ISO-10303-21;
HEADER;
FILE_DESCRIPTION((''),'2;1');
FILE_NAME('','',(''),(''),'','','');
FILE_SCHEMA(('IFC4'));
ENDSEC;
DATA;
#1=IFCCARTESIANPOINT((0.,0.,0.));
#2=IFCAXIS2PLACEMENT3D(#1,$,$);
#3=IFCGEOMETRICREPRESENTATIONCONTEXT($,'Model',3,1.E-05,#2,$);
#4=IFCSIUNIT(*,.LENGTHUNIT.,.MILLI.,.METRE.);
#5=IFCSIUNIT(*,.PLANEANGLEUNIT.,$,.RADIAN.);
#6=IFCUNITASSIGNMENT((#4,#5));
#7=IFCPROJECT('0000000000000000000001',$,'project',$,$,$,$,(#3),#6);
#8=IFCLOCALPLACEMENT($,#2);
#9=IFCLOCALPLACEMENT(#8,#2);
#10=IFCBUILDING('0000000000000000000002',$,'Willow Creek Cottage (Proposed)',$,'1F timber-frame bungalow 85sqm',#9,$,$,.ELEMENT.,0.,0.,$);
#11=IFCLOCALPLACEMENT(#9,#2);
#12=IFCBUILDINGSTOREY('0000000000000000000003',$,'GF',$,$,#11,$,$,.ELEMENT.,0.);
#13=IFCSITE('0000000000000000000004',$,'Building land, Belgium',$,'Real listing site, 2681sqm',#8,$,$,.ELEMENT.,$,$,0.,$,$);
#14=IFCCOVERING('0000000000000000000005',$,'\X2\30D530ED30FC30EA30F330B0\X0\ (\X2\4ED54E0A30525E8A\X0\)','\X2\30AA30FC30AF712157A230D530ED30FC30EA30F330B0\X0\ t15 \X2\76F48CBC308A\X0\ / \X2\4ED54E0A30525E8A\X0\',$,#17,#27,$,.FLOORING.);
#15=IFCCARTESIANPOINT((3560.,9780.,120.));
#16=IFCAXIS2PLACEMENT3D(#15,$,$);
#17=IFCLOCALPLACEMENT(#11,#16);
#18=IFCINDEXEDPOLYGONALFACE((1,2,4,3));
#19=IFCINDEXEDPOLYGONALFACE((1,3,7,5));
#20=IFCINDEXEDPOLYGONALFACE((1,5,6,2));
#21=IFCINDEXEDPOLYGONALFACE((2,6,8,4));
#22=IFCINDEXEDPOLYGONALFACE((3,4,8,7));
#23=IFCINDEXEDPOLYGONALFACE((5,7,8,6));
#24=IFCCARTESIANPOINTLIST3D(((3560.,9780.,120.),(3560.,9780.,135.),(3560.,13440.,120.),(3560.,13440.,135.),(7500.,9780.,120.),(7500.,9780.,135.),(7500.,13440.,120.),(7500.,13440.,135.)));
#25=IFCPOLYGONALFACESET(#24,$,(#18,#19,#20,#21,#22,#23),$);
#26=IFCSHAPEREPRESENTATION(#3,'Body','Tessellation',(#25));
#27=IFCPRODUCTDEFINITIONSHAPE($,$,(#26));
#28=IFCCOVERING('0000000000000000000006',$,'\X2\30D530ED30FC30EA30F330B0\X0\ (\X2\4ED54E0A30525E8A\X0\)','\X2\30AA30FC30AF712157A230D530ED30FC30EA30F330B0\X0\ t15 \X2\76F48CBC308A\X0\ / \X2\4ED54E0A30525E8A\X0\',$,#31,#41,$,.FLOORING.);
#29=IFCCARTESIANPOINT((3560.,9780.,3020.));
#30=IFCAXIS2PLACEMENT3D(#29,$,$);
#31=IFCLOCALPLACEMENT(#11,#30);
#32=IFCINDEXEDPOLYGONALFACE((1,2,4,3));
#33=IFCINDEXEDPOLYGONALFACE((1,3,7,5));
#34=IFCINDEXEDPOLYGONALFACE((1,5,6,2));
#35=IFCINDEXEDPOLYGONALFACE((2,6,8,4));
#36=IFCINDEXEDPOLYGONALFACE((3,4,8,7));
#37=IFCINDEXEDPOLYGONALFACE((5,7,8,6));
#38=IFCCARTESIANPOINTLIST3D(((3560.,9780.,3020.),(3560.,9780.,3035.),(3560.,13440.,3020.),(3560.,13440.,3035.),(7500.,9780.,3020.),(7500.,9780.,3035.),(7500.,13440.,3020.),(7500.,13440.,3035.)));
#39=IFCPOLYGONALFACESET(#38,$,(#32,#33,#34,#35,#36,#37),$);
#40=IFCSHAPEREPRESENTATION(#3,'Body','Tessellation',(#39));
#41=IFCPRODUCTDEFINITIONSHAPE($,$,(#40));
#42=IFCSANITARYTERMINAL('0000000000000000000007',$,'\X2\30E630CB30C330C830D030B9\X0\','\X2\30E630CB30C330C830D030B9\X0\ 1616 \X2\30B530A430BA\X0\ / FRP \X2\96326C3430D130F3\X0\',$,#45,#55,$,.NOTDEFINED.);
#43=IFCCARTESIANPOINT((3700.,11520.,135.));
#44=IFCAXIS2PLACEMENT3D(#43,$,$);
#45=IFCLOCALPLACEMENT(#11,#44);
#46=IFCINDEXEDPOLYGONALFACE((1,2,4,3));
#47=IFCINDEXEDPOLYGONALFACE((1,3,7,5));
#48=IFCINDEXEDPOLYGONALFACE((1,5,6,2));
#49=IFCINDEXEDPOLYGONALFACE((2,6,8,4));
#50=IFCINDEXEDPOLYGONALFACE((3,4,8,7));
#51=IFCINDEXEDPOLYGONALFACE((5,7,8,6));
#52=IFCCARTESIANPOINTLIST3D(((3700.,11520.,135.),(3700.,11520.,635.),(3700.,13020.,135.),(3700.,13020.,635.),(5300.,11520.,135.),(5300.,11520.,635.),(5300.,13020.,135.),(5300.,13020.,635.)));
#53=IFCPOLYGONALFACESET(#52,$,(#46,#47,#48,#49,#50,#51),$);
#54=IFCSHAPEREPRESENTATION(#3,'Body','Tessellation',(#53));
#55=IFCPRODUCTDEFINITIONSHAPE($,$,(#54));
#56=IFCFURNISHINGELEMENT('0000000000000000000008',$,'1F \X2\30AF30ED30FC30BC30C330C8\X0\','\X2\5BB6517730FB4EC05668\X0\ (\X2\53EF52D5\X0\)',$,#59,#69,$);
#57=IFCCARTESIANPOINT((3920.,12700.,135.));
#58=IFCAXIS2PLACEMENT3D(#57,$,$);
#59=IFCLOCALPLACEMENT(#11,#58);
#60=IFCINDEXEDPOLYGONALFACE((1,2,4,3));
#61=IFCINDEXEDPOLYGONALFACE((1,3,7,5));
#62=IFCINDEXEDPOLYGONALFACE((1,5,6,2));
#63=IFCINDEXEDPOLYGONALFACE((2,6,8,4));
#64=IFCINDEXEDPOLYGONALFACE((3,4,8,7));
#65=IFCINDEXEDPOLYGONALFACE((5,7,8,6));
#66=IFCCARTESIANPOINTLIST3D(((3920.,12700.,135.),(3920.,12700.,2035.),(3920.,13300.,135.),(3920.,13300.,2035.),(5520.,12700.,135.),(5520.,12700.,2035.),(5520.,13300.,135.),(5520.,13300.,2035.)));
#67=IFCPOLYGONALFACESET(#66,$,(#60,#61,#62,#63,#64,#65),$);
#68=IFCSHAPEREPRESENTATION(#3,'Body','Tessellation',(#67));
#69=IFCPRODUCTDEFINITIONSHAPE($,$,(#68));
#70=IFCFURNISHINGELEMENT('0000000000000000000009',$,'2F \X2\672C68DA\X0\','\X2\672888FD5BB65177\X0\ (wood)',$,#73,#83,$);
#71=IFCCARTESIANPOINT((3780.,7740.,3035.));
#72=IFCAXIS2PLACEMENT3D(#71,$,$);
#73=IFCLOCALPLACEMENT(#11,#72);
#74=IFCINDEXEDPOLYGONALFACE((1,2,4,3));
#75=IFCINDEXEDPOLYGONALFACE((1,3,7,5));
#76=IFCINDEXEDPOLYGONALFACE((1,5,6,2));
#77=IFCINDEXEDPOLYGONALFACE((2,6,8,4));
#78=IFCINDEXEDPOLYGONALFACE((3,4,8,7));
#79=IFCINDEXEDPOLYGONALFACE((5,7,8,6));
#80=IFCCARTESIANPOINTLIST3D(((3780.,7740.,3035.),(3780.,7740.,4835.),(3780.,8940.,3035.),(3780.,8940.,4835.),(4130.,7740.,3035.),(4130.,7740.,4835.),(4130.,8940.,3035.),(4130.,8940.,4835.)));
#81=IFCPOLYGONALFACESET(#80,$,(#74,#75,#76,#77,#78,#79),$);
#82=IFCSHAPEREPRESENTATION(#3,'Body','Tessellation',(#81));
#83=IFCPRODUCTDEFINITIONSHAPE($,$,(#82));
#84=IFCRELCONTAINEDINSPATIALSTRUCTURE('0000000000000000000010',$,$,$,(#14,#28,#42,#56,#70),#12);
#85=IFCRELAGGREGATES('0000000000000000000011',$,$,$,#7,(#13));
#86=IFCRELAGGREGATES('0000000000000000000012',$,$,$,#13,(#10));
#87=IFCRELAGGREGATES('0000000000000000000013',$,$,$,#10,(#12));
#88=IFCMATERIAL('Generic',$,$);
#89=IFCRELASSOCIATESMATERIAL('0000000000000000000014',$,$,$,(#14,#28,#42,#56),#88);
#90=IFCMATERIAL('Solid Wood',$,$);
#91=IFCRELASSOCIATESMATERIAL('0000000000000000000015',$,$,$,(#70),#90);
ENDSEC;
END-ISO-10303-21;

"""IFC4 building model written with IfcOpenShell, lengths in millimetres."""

from ifc_helpers import new_model, si_unit, frame, frame_2d, origin, place, context, project, spatial, rectangle, extrude, material, element, save


model = new_model("IFC4")

# Units and contexts
model_context = context("Model", 3, precision=1e-05, world=origin())
ifc_project = project(units=[si_unit("LENGTHUNIT", "METRE", prefix="MILLI"), si_unit("PLANEANGLEUNIT", "RADIAN")], contexts=[model_context])

# Site, building, storey
site_placement = place(None, origin())
site = spatial("IfcSite", under=ifc_project, at=site_placement, Name="Building land, Belgium", ObjectType="Real listing site, 2681sqm", CompositionType="ELEMENT", RefElevation=0.0)
building_placement = place(site_placement, origin())
building = spatial("IfcBuilding", under=site, at=building_placement, Name="Willow Creek Cottage (Proposed)", ObjectType="1F timber-frame bungalow 85sqm", CompositionType="ELEMENT", ElevationOfRefHeight=0.0, ElevationOfTerrain=0.0)
storey_placement = place(building_placement, origin())
storey = spatial("IfcBuildingStorey", under=building, at=storey_placement, Name="GF", CompositionType="ELEMENT", Elevation=0.0)

# Shared definitions
ifc_material_1 = material(Name="Solid Wood")

# Coverings
ifc_material_2 = material(Name="Generic")
covering_1_placement = place(storey_placement, frame((3560.0, 9780.0, 120.0)))
element("IfcCovering", 1, at=covering_1_placement, inside=storey, material=ifc_material_2, Name="フローリング (仕上げ床)", Description="オーク無垢フローリング t15 直貼り / 仕上げ床", PredefinedType="FLOORING", context=model_context, shape_type="SweptSolid", body=[
    extrude(rectangle(XDim=3940.0, YDim=3660.0, at=frame_2d((1970.0, 1830.0))), frame((3560.0, 9780.0, 120.0)), (0.0, 0.0, 1.0), 15.0),
])
covering_2_placement = place(storey_placement, frame((3560.0, 9780.0, 3020.0)))
element("IfcCovering", 2, at=covering_2_placement, inside=storey, material=ifc_material_2, Name="フローリング (仕上げ床)", Description="オーク無垢フローリング t15 直貼り / 仕上げ床", PredefinedType="FLOORING", context=model_context, shape_type="SweptSolid", body=[
    extrude(rectangle(XDim=3940.0, YDim=3660.0, at=frame_2d((1970.0, 1830.0))), frame((3560.0, 9780.0, 3020.0)), (0.0, 0.0, 1.0), 15.0),
])

# Sanitary terminal
sanitary_terminal_placement = place(storey_placement, frame((3700.0, 11520.0, 135.0)))
element("IfcSanitaryTerminal", 3, at=sanitary_terminal_placement, inside=storey, material=ifc_material_2, Name="ユニットバス", Description="ユニットバス 1616 サイズ / FRP 防水パン", PredefinedType="NOTDEFINED", context=model_context, shape_type="SweptSolid", body=[
    extrude(rectangle(XDim=1600.0, YDim=1500.0, at=frame_2d((800.0, 750.0))), frame((3700.0, 11520.0, 135.0)), (0.0, 0.0, 1.0), 500.0),
])

# Furnishing elements
furnishing_1_placement = place(storey_placement, frame((3920.0, 12700.0, 135.0)))
element("IfcFurnishingElement", 4, at=furnishing_1_placement, inside=storey, material=ifc_material_2, Name="1F クローゼット", Description="家具・什器 (可動)", context=model_context, shape_type="SweptSolid", body=[
    extrude(rectangle(XDim=1600.0, YDim=600.0, at=frame_2d((800.0, 300.0))), frame((3920.0, 12700.0, 135.0)), (0.0, 0.0, 1.0), 1900.0),
])
furnishing_2_placement = place(storey_placement, frame((3780.0, 7740.0, 3035.0)))
element("IfcFurnishingElement", 5, at=furnishing_2_placement, inside=storey, material=ifc_material_1, Name="2F 本棚", Description="木製家具 (wood)", context=model_context, shape_type="SweptSolid", body=[
    extrude(rectangle(XDim=350.0, YDim=1200.0, at=frame_2d((175.0, 600.0))), frame((3780.0, 7740.0, 3035.0)), (0.0, 0.0, 1.0), 1800.0),
])

save(model, "model.ifc")
